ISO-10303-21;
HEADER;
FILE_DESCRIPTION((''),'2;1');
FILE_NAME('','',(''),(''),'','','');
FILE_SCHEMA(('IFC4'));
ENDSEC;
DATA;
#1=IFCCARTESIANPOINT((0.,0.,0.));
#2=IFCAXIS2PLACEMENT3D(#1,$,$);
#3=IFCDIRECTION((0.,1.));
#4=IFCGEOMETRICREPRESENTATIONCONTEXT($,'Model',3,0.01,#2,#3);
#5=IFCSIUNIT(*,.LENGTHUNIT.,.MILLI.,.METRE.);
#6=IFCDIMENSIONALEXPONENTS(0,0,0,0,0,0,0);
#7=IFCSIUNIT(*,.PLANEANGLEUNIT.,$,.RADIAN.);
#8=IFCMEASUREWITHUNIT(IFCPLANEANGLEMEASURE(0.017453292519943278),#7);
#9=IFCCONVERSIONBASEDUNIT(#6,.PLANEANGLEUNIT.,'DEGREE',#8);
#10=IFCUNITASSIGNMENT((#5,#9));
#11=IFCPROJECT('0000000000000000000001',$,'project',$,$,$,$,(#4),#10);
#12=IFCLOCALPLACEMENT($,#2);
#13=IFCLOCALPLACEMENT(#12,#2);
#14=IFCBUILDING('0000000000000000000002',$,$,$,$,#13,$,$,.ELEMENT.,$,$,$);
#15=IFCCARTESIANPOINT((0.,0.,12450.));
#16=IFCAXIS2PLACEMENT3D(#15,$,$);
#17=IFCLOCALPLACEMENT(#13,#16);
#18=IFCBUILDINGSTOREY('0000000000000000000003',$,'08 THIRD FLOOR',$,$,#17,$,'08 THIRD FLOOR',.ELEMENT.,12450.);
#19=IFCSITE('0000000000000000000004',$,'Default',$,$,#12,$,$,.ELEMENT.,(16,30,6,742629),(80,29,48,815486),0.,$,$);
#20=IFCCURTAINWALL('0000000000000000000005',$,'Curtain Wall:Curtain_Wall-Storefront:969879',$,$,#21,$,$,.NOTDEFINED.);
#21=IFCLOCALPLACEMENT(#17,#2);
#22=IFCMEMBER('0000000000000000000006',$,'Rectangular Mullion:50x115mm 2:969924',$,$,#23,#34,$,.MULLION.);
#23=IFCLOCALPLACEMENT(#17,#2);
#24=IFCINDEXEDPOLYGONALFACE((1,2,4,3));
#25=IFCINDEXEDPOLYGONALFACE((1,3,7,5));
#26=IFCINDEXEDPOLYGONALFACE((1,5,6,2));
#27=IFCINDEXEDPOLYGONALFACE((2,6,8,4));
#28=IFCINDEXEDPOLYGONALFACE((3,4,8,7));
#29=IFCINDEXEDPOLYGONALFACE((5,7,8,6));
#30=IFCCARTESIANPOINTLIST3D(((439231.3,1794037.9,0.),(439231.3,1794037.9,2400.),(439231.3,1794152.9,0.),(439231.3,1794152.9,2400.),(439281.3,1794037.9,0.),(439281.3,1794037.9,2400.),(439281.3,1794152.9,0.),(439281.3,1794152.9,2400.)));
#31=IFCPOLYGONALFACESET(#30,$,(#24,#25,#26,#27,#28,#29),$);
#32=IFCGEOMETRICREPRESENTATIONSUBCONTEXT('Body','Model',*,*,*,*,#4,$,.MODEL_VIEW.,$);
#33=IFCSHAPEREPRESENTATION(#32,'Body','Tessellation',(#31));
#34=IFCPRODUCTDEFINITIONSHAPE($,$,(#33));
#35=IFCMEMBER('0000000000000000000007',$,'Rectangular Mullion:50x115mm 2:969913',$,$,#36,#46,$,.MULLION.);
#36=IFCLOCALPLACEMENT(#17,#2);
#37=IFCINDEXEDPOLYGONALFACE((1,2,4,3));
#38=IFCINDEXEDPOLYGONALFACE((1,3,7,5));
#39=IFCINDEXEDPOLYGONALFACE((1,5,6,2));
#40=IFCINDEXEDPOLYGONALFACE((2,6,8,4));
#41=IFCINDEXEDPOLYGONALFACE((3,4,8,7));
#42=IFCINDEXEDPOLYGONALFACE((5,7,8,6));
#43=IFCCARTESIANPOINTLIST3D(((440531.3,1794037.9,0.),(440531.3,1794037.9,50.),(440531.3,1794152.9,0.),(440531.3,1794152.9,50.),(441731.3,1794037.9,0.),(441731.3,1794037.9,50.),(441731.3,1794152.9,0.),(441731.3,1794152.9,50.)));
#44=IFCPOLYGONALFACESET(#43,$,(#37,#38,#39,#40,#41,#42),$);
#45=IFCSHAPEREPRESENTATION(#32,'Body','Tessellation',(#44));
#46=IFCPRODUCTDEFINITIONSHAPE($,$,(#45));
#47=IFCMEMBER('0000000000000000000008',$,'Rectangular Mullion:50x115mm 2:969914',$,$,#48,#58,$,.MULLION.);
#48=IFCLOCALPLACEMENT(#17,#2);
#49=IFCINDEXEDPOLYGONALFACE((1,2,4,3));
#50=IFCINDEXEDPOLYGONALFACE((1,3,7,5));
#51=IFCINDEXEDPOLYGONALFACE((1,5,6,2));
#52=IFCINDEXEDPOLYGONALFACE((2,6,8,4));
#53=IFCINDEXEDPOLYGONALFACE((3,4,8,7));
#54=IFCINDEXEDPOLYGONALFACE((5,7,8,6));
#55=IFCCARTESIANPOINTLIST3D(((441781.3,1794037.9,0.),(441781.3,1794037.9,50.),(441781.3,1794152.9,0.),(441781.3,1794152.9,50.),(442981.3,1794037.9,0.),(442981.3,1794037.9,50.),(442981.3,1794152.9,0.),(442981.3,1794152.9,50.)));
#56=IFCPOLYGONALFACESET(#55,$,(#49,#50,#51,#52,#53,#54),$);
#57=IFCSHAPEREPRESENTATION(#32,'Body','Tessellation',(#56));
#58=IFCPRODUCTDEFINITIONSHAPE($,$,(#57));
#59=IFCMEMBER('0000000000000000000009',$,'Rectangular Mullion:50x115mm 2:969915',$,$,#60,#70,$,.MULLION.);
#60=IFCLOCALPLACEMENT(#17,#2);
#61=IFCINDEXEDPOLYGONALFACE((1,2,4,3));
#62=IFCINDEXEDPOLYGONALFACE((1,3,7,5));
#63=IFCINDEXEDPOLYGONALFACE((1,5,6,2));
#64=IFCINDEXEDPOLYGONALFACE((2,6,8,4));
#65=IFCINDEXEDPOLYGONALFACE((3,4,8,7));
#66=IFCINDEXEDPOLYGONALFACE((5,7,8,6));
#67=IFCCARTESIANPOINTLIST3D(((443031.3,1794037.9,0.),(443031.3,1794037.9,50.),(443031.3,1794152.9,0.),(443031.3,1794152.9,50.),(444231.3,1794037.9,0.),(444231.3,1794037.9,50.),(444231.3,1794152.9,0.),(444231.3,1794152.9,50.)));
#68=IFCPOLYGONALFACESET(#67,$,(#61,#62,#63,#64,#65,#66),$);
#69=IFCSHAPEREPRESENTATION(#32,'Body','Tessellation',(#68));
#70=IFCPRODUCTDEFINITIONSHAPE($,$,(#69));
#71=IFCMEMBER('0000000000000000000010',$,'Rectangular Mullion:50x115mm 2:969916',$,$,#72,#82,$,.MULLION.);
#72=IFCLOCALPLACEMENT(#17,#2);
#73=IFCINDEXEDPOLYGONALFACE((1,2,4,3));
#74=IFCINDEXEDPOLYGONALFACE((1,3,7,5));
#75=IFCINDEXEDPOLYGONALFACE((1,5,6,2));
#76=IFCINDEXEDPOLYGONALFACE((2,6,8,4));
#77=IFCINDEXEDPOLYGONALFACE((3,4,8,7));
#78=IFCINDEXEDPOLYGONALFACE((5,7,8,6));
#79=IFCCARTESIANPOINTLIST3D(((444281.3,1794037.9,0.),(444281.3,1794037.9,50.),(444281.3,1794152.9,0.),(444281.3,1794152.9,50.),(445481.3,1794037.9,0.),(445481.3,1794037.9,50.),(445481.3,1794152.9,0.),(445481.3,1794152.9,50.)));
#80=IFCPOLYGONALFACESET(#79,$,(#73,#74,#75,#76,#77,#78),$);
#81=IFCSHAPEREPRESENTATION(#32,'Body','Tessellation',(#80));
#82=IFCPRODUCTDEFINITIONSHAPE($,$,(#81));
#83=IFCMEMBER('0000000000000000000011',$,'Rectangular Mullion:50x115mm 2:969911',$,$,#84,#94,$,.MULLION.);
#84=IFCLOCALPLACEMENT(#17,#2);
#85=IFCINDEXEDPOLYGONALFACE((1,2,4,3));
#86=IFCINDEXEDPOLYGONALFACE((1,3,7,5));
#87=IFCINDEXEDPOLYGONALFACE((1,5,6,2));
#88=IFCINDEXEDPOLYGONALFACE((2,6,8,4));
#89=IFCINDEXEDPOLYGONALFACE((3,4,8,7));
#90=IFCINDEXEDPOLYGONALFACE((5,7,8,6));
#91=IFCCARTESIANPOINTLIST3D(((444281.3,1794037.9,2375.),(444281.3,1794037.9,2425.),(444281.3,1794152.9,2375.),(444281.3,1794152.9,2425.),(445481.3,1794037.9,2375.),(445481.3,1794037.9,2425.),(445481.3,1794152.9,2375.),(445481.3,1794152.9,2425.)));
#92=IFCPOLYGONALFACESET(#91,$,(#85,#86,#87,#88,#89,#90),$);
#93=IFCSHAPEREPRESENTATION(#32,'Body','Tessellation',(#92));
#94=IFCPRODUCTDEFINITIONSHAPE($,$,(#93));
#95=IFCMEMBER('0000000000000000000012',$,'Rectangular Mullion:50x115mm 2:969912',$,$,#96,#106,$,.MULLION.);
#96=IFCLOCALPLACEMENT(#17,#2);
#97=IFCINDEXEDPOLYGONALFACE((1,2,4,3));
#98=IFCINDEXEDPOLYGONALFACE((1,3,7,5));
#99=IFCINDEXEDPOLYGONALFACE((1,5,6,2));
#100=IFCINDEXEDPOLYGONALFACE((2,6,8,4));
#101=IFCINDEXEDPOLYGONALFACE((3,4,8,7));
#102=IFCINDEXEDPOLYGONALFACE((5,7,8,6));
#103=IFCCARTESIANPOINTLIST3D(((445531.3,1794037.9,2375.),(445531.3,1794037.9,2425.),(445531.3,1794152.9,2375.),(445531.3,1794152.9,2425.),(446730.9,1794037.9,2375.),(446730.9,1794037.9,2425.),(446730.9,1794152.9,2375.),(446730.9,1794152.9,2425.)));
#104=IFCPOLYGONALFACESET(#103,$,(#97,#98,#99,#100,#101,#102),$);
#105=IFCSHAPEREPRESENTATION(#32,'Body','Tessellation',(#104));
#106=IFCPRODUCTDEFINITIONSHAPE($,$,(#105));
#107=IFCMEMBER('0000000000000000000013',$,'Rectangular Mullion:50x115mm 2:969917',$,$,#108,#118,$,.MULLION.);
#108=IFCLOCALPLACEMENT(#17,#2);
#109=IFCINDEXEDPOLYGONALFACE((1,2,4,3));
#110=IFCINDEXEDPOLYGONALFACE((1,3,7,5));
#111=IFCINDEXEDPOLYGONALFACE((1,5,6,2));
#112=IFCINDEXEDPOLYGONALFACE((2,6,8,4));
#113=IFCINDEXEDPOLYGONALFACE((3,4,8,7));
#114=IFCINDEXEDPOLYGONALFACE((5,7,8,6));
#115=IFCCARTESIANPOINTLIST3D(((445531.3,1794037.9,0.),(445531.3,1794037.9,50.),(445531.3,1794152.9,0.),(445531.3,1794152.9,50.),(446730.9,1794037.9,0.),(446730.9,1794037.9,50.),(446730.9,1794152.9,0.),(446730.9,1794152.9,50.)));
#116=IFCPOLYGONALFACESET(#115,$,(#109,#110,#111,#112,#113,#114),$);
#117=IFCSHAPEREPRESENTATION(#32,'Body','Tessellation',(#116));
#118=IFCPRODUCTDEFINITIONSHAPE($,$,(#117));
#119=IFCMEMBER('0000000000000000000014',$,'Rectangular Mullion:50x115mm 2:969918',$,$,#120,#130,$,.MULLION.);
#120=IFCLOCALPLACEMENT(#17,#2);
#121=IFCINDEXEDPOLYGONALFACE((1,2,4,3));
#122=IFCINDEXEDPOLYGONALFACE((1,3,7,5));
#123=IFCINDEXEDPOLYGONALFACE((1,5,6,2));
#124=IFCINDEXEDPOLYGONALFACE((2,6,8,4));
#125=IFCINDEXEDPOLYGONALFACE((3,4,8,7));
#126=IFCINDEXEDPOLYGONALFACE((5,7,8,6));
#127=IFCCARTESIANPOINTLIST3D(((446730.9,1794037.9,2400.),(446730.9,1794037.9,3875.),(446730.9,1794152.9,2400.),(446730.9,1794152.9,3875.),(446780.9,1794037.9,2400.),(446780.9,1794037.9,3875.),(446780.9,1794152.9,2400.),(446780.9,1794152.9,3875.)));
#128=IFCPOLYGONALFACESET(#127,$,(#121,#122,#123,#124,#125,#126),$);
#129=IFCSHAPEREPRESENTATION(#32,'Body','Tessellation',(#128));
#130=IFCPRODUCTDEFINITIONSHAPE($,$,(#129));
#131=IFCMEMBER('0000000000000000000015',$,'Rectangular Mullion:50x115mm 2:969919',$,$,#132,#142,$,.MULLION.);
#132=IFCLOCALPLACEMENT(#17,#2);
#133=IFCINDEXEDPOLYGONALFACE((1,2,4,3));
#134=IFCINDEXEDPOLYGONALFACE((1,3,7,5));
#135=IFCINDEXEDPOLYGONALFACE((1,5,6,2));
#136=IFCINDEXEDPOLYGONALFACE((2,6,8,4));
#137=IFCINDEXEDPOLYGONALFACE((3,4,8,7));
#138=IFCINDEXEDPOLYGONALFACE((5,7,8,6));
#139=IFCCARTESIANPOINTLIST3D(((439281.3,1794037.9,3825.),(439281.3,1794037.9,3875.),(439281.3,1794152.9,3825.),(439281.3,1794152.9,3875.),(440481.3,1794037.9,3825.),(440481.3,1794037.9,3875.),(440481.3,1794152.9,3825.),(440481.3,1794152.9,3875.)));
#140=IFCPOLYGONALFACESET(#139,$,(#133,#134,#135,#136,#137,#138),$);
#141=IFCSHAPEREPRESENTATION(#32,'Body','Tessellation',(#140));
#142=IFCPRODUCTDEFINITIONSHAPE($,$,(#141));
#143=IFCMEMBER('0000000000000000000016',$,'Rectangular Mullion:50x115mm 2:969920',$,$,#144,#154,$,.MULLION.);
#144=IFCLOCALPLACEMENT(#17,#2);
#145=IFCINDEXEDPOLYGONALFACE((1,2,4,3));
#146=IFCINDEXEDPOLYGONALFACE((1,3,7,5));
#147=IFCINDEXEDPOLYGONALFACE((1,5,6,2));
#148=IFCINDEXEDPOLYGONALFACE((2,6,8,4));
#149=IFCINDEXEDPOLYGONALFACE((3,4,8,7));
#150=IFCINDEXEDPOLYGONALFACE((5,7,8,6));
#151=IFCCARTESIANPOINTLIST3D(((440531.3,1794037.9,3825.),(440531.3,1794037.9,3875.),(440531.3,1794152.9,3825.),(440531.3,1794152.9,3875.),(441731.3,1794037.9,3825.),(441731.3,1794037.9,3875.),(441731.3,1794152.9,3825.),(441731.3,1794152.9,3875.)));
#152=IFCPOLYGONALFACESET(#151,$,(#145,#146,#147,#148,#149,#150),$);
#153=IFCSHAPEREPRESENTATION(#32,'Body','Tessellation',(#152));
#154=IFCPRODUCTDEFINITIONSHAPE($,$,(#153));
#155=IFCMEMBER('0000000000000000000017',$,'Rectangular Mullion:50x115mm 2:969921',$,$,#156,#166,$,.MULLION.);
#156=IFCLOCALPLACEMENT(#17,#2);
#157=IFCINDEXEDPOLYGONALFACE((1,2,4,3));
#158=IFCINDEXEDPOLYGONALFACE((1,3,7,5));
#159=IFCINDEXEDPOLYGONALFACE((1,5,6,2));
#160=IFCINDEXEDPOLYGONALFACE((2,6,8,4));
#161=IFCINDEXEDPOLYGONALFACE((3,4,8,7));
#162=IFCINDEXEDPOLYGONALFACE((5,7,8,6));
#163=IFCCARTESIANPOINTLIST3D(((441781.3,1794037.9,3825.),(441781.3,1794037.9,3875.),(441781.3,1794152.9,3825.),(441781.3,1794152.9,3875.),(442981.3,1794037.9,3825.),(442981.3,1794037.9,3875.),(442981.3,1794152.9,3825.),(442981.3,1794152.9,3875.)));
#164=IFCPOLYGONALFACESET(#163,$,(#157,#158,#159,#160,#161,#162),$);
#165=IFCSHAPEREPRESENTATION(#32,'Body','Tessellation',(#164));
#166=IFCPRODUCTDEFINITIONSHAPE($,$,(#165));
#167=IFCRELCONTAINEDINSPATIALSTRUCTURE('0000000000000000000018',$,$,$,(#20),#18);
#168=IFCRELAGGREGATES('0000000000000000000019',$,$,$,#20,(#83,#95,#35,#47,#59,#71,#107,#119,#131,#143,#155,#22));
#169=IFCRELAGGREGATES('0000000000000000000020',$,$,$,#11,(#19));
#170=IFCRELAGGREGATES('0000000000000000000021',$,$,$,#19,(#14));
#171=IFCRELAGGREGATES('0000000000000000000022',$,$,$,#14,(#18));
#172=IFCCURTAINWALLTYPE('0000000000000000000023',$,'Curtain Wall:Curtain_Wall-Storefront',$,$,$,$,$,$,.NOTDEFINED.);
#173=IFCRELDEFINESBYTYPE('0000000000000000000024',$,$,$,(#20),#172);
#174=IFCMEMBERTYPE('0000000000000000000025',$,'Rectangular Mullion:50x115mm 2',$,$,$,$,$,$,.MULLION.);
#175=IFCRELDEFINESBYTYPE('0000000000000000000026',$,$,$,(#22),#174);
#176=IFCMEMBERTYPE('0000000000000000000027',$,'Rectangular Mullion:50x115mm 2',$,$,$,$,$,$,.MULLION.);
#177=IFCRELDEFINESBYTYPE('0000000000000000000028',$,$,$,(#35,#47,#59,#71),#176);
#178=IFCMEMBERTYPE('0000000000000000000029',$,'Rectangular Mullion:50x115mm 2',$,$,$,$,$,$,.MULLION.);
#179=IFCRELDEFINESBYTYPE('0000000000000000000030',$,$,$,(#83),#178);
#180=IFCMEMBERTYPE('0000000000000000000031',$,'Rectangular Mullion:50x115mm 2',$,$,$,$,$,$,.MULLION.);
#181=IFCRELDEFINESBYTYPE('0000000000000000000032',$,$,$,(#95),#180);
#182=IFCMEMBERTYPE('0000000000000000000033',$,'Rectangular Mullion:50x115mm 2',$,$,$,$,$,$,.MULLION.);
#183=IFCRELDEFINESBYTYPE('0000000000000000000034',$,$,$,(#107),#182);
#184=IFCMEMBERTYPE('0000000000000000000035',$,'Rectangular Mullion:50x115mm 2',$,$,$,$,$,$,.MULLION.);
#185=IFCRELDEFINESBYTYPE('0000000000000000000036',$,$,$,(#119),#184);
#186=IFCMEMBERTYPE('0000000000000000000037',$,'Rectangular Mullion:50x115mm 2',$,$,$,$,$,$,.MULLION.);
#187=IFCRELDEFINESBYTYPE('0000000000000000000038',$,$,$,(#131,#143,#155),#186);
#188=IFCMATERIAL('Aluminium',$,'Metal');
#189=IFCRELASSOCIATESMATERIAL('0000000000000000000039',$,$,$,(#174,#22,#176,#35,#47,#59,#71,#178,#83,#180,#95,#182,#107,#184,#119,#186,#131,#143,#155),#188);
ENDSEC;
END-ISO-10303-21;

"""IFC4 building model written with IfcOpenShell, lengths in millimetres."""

from ifc_helpers import new_model, entity, si_unit, converted_unit, direction, frame, origin, place, context, subcontext, project, spatial, indexed_curve, outline, extrude, source, transform, mapped, material, type_object, type_shapes, element, aggregate, save


model = new_model("IFC4")

# Units and contexts
model_context = context("Model", 3, precision=0.01, world=origin(), true_north=direction((0.0, 1.0)))
body_context = subcontext(model_context, "Body", "Model", "MODEL_VIEW")
ifc_project = project(units=[si_unit("LENGTHUNIT", "METRE", prefix="MILLI"), converted_unit("PLANEANGLEUNIT", "DEGREE", entity("IfcPlaneAngleMeasure", 0.017453292519943278), si_unit("PLANEANGLEUNIT", "RADIAN"), dimensions=[0, 0, 0, 0, 0, 0, 0])], contexts=[model_context])

# Site, building, storey
site_placement = place(None, origin())
site = spatial("IfcSite", under=ifc_project, at=site_placement, Name="Default", CompositionType="ELEMENT", RefLatitude=(16, 30, 6, 742629), RefLongitude=(80, 29, 48, 815486), RefElevation=0.0)
building_placement = place(site_placement, origin())
building = spatial("IfcBuilding", under=site, at=building_placement, CompositionType="ELEMENT")
storey_placement = place(building_placement, frame((0.0, 0.0, 12450.0)))
storey = spatial("IfcBuildingStorey", under=building, at=storey_placement, Name="08 THIRD FLOOR", LongName="08 THIRD FLOOR", CompositionType="ELEMENT", Elevation=12450.0)

# Curtain wall, members
curtain_wall_type = type_object("IfcCurtainWallType", Name="Curtain Wall:Curtain_Wall-Storefront", PredefinedType="NOTDEFINED")
curtain_wall_placement = place(storey_placement, frame((0.0, 0.0, -12450.0)))
curtain_wall = element("IfcCurtainWall", 1, at=curtain_wall_placement, inside=storey, type_object=curtain_wall_type, Name="Curtain Wall:Curtain_Wall-Storefront:969879", PredefinedType="NOTDEFINED")
ifc_material_1 = material(Name="Aluminium", Category="Metal")
member_type_1 = type_object("IfcMemberType", Name="Rectangular Mullion:50x115mm 2", PredefinedType="MULLION", material=ifc_material_1)
shared_shape_1 = source(origin(), body_context, "Body", "SweptSolid", [
    extrude(outline(indexed_curve([(-25.0, -57.5), (25.0, -57.5), (25.0, 57.5), (-25.0, 57.5), (-25.0, -57.5)], self_intersect=False)), frame((-25.0, 0.0, -2400.0), z_axis=(0.0, 0.0, 1.0), x_axis=(-1.0, 0.0, 0.0)), (0.0, 0.0, 1.0), 2400.0),
])
type_shapes(member_type_1, [shared_shape_1])
member_1_placement = place(curtain_wall_placement, frame((439231.3, 1794095.4, 14850.0), z_axis=(0.0, 0.0, 1.0), x_axis=(-1.0, 0.0, 0.0)))
member_1 = element("IfcMember", 2, at=member_1_placement, type_object=member_type_1, material=ifc_material_1, Name="Rectangular Mullion:50x115mm 2:969924", PredefinedType="MULLION", context=body_context, shape_type="MappedRepresentation", body=[
    mapped(shared_shape_1, transform((0.0, 0.0, 0.0), scale=1.0)),
])
member_type_2 = type_object("IfcMemberType", Name="Rectangular Mullion:50x115mm 2", PredefinedType="MULLION", material=ifc_material_1)
shared_shape_2 = source(origin(), body_context, "Body", "SweptSolid", [
    extrude(outline(indexed_curve([(-25.0, -57.5), (25.0, -57.5), (25.0, 57.5), (-25.0, 57.5), (-25.0, -57.5)], self_intersect=False)), frame((-25.0, 0.0, -1200.0), z_axis=(0.0, 0.0, 1.0), x_axis=(-1.0, 0.0, 0.0)), (0.0, 0.0, 1.0), 1200.0),
])
type_shapes(member_type_2, [shared_shape_2])
member_2_placement = place(curtain_wall_placement, frame((440531.3, 1794095.4, 12450.0), z_axis=(-1.0, 0.0, 0.0), x_axis=(0.0, 0.0, -1.0)))
member_2 = element("IfcMember", 3, at=member_2_placement, type_object=member_type_2, material=ifc_material_1, Name="Rectangular Mullion:50x115mm 2:969913", PredefinedType="MULLION", context=body_context, shape_type="MappedRepresentation", body=[
    mapped(shared_shape_2, transform((0.0, 0.0, 0.0), scale=1.0)),
])
member_3_placement = place(curtain_wall_placement, frame((441781.3, 1794095.4, 12450.0), z_axis=(-1.0, 0.0, 0.0), x_axis=(0.0, 0.0, -1.0)))
member_3 = element("IfcMember", 4, at=member_3_placement, type_object=member_type_2, material=ifc_material_1, Name="Rectangular Mullion:50x115mm 2:969914", PredefinedType="MULLION", context=body_context, shape_type="MappedRepresentation", body=[
    mapped(shared_shape_2, transform((0.0, 0.0, 0.0), scale=1.0)),
])
member_4_placement = place(curtain_wall_placement, frame((443031.3, 1794095.4, 12450.0), z_axis=(-1.0, 0.0, 0.0), x_axis=(0.0, 0.0, -1.0)))
member_4 = element("IfcMember", 5, at=member_4_placement, type_object=member_type_2, material=ifc_material_1, Name="Rectangular Mullion:50x115mm 2:969915", PredefinedType="MULLION", context=body_context, shape_type="MappedRepresentation", body=[
    mapped(shared_shape_2, transform((0.0, 0.0, 0.0), scale=1.0)),
])
member_5_placement = place(curtain_wall_placement, frame((444281.3, 1794095.4, 12450.0), z_axis=(-1.0, 0.0, 0.0), x_axis=(0.0, 0.0, -1.0)))
member_5 = element("IfcMember", 6, at=member_5_placement, type_object=member_type_2, material=ifc_material_1, Name="Rectangular Mullion:50x115mm 2:969916", PredefinedType="MULLION", context=body_context, shape_type="MappedRepresentation", body=[
    mapped(shared_shape_2, transform((0.0, 0.0, 0.0), scale=1.0)),
])
member_type_3 = type_object("IfcMemberType", Name="Rectangular Mullion:50x115mm 2", PredefinedType="MULLION", material=ifc_material_1)
shared_shape_3 = source(origin(), body_context, "Body", "SweptSolid", [
    extrude(outline(indexed_curve([(-25.0, -57.5), (25.0, -57.5), (25.0, 57.5), (-25.0, 57.5), (-25.0, -57.5)], self_intersect=False)), frame((0.0, 0.0, -1200.0), z_axis=(0.0, 0.0, 1.0), x_axis=(-1.0, 0.0, 0.0)), (0.0, 0.0, 1.0), 1200.0),
])
type_shapes(member_type_3, [shared_shape_3])
member_6_placement = place(curtain_wall_placement, frame((445481.3, 1794095.4, 14850.0), z_axis=(1.0, 0.0, 0.0), x_axis=(0.0, 0.0, 1.0)))
member_6 = element("IfcMember", 7, at=member_6_placement, type_object=member_type_3, material=ifc_material_1, Name="Rectangular Mullion:50x115mm 2:969911", PredefinedType="MULLION", context=body_context, shape_type="MappedRepresentation", body=[
    mapped(shared_shape_3, transform((0.0, 0.0, 0.0), scale=1.0)),
])
member_type_4 = type_object("IfcMemberType", Name="Rectangular Mullion:50x115mm 2", PredefinedType="MULLION", material=ifc_material_1)
shared_shape_4 = source(origin(), body_context, "Body", "SweptSolid", [
    extrude(outline(indexed_curve([(-25.0, -57.5), (25.0, -57.5), (25.0, 57.5), (-25.0, 57.5), (-25.0, -57.5)], self_intersect=False)), frame((0.0, 0.0, -1199.6), z_axis=(0.0, 0.0, 1.0), x_axis=(-1.0, 0.0, 0.0)), (0.0, 0.0, 1.0), 1199.6),
])
type_shapes(member_type_4, [shared_shape_4])
member_7_placement = place(curtain_wall_placement, frame((446730.9, 1794095.4, 14850.0), z_axis=(1.0, 0.0, 0.0), x_axis=(0.0, 0.0, 1.0)))
member_7 = element("IfcMember", 8, at=member_7_placement, type_object=member_type_4, material=ifc_material_1, Name="Rectangular Mullion:50x115mm 2:969912", PredefinedType="MULLION", context=body_context, shape_type="MappedRepresentation", body=[
    mapped(shared_shape_4, transform((0.0, 0.0, 0.0), scale=1.0)),
])
member_type_5 = type_object("IfcMemberType", Name="Rectangular Mullion:50x115mm 2", PredefinedType="MULLION", material=ifc_material_1)
shared_shape_5 = source(origin(), body_context, "Body", "SweptSolid", [
    extrude(outline(indexed_curve([(-25.0, -57.5), (25.0, -57.5), (25.0, 57.5), (-25.0, 57.5), (-25.0, -57.5)], self_intersect=False)), frame((-25.0, 0.0, -1199.6), z_axis=(0.0, 0.0, 1.0), x_axis=(-1.0, 0.0, 0.0)), (0.0, 0.0, 1.0), 1199.6),
])
type_shapes(member_type_5, [shared_shape_5])
member_8_placement = place(curtain_wall_placement, frame((445531.3, 1794095.4, 12450.0), z_axis=(-1.0, 0.0, 0.0), x_axis=(0.0, 0.0, -1.0)))
member_8 = element("IfcMember", 9, at=member_8_placement, type_object=member_type_5, material=ifc_material_1, Name="Rectangular Mullion:50x115mm 2:969917", PredefinedType="MULLION", context=body_context, shape_type="MappedRepresentation", body=[
    mapped(shared_shape_5, transform((0.0, 0.0, 0.0), scale=1.0)),
])
member_type_6 = type_object("IfcMemberType", Name="Rectangular Mullion:50x115mm 2", PredefinedType="MULLION", material=ifc_material_1)
shared_shape_6 = source(origin(), body_context, "Body", "SweptSolid", [
    extrude(outline(indexed_curve([(-25.0, -57.5), (25.0, -57.5), (25.0, 57.5), (-25.0, 57.5), (-25.0, -57.5)], self_intersect=False)), frame((-25.0, 0.0, -1475.0), z_axis=(0.0, 0.0, 1.0), x_axis=(-1.0, 0.0, 0.0)), (0.0, 0.0, 1.0), 1475.0),
])
type_shapes(member_type_6, [shared_shape_6])
member_9_placement = place(curtain_wall_placement, frame((446780.9, 1794095.4, 14850.0), z_axis=(0.0, 0.0, -1.0), x_axis=(1.0, 0.0, 0.0)))
member_9 = element("IfcMember", 10, at=member_9_placement, type_object=member_type_6, material=ifc_material_1, Name="Rectangular Mullion:50x115mm 2:969918", PredefinedType="MULLION", context=body_context, shape_type="MappedRepresentation", body=[
    mapped(shared_shape_6, transform((0.0, 0.0, 0.0), scale=1.0)),
])
member_type_7 = type_object("IfcMemberType", Name="Rectangular Mullion:50x115mm 2", PredefinedType="MULLION", material=ifc_material_1)
shared_shape_7 = source(origin(), body_context, "Body", "SweptSolid", [
    extrude(outline(indexed_curve([(-25.0, -57.5), (25.0, -57.5), (25.0, 57.5), (-25.0, 57.5), (-25.0, -57.5)], self_intersect=False)), frame((-25.0, 0.0, -1200.0), z_axis=(0.0, 0.0, 1.0), x_axis=(-1.0, 0.0, 0.0)), (0.0, 0.0, 1.0), 1200.0),
])
type_shapes(member_type_7, [shared_shape_7])
member_10_placement = place(curtain_wall_placement, frame((440481.3, 1794095.4, 16325.0), z_axis=(1.0, 0.0, 0.0), x_axis=(0.0, 0.0, 1.0)))
member_10 = element("IfcMember", 11, at=member_10_placement, type_object=member_type_7, material=ifc_material_1, Name="Rectangular Mullion:50x115mm 2:969919", PredefinedType="MULLION", context=body_context, shape_type="MappedRepresentation", body=[
    mapped(shared_shape_7, transform((0.0, 0.0, 0.0), scale=1.0)),
])
member_11_placement = place(curtain_wall_placement, frame((441731.3, 1794095.4, 16325.0), z_axis=(1.0, 0.0, 0.0), x_axis=(0.0, 0.0, 1.0)))
member_11 = element("IfcMember", 12, at=member_11_placement, type_object=member_type_7, material=ifc_material_1, Name="Rectangular Mullion:50x115mm 2:969920", PredefinedType="MULLION", context=body_context, shape_type="MappedRepresentation", body=[
    mapped(shared_shape_7, transform((0.0, 0.0, 0.0), scale=1.0)),
])
member_12_placement = place(curtain_wall_placement, frame((442981.3, 1794095.4, 16325.0), z_axis=(1.0, 0.0, 0.0), x_axis=(0.0, 0.0, 1.0)))
member_12 = element("IfcMember", 13, at=member_12_placement, type_object=member_type_7, material=ifc_material_1, Name="Rectangular Mullion:50x115mm 2:969921", PredefinedType="MULLION", context=body_context, shape_type="MappedRepresentation", body=[
    mapped(shared_shape_7, transform((0.0, 0.0, 0.0), scale=1.0)),
])
aggregate(curtain_wall, [member_6, member_7, member_2, member_3, member_4, member_5, member_8, member_9, member_10, member_11, member_12, member_1])

save(model, "model.ifc")
